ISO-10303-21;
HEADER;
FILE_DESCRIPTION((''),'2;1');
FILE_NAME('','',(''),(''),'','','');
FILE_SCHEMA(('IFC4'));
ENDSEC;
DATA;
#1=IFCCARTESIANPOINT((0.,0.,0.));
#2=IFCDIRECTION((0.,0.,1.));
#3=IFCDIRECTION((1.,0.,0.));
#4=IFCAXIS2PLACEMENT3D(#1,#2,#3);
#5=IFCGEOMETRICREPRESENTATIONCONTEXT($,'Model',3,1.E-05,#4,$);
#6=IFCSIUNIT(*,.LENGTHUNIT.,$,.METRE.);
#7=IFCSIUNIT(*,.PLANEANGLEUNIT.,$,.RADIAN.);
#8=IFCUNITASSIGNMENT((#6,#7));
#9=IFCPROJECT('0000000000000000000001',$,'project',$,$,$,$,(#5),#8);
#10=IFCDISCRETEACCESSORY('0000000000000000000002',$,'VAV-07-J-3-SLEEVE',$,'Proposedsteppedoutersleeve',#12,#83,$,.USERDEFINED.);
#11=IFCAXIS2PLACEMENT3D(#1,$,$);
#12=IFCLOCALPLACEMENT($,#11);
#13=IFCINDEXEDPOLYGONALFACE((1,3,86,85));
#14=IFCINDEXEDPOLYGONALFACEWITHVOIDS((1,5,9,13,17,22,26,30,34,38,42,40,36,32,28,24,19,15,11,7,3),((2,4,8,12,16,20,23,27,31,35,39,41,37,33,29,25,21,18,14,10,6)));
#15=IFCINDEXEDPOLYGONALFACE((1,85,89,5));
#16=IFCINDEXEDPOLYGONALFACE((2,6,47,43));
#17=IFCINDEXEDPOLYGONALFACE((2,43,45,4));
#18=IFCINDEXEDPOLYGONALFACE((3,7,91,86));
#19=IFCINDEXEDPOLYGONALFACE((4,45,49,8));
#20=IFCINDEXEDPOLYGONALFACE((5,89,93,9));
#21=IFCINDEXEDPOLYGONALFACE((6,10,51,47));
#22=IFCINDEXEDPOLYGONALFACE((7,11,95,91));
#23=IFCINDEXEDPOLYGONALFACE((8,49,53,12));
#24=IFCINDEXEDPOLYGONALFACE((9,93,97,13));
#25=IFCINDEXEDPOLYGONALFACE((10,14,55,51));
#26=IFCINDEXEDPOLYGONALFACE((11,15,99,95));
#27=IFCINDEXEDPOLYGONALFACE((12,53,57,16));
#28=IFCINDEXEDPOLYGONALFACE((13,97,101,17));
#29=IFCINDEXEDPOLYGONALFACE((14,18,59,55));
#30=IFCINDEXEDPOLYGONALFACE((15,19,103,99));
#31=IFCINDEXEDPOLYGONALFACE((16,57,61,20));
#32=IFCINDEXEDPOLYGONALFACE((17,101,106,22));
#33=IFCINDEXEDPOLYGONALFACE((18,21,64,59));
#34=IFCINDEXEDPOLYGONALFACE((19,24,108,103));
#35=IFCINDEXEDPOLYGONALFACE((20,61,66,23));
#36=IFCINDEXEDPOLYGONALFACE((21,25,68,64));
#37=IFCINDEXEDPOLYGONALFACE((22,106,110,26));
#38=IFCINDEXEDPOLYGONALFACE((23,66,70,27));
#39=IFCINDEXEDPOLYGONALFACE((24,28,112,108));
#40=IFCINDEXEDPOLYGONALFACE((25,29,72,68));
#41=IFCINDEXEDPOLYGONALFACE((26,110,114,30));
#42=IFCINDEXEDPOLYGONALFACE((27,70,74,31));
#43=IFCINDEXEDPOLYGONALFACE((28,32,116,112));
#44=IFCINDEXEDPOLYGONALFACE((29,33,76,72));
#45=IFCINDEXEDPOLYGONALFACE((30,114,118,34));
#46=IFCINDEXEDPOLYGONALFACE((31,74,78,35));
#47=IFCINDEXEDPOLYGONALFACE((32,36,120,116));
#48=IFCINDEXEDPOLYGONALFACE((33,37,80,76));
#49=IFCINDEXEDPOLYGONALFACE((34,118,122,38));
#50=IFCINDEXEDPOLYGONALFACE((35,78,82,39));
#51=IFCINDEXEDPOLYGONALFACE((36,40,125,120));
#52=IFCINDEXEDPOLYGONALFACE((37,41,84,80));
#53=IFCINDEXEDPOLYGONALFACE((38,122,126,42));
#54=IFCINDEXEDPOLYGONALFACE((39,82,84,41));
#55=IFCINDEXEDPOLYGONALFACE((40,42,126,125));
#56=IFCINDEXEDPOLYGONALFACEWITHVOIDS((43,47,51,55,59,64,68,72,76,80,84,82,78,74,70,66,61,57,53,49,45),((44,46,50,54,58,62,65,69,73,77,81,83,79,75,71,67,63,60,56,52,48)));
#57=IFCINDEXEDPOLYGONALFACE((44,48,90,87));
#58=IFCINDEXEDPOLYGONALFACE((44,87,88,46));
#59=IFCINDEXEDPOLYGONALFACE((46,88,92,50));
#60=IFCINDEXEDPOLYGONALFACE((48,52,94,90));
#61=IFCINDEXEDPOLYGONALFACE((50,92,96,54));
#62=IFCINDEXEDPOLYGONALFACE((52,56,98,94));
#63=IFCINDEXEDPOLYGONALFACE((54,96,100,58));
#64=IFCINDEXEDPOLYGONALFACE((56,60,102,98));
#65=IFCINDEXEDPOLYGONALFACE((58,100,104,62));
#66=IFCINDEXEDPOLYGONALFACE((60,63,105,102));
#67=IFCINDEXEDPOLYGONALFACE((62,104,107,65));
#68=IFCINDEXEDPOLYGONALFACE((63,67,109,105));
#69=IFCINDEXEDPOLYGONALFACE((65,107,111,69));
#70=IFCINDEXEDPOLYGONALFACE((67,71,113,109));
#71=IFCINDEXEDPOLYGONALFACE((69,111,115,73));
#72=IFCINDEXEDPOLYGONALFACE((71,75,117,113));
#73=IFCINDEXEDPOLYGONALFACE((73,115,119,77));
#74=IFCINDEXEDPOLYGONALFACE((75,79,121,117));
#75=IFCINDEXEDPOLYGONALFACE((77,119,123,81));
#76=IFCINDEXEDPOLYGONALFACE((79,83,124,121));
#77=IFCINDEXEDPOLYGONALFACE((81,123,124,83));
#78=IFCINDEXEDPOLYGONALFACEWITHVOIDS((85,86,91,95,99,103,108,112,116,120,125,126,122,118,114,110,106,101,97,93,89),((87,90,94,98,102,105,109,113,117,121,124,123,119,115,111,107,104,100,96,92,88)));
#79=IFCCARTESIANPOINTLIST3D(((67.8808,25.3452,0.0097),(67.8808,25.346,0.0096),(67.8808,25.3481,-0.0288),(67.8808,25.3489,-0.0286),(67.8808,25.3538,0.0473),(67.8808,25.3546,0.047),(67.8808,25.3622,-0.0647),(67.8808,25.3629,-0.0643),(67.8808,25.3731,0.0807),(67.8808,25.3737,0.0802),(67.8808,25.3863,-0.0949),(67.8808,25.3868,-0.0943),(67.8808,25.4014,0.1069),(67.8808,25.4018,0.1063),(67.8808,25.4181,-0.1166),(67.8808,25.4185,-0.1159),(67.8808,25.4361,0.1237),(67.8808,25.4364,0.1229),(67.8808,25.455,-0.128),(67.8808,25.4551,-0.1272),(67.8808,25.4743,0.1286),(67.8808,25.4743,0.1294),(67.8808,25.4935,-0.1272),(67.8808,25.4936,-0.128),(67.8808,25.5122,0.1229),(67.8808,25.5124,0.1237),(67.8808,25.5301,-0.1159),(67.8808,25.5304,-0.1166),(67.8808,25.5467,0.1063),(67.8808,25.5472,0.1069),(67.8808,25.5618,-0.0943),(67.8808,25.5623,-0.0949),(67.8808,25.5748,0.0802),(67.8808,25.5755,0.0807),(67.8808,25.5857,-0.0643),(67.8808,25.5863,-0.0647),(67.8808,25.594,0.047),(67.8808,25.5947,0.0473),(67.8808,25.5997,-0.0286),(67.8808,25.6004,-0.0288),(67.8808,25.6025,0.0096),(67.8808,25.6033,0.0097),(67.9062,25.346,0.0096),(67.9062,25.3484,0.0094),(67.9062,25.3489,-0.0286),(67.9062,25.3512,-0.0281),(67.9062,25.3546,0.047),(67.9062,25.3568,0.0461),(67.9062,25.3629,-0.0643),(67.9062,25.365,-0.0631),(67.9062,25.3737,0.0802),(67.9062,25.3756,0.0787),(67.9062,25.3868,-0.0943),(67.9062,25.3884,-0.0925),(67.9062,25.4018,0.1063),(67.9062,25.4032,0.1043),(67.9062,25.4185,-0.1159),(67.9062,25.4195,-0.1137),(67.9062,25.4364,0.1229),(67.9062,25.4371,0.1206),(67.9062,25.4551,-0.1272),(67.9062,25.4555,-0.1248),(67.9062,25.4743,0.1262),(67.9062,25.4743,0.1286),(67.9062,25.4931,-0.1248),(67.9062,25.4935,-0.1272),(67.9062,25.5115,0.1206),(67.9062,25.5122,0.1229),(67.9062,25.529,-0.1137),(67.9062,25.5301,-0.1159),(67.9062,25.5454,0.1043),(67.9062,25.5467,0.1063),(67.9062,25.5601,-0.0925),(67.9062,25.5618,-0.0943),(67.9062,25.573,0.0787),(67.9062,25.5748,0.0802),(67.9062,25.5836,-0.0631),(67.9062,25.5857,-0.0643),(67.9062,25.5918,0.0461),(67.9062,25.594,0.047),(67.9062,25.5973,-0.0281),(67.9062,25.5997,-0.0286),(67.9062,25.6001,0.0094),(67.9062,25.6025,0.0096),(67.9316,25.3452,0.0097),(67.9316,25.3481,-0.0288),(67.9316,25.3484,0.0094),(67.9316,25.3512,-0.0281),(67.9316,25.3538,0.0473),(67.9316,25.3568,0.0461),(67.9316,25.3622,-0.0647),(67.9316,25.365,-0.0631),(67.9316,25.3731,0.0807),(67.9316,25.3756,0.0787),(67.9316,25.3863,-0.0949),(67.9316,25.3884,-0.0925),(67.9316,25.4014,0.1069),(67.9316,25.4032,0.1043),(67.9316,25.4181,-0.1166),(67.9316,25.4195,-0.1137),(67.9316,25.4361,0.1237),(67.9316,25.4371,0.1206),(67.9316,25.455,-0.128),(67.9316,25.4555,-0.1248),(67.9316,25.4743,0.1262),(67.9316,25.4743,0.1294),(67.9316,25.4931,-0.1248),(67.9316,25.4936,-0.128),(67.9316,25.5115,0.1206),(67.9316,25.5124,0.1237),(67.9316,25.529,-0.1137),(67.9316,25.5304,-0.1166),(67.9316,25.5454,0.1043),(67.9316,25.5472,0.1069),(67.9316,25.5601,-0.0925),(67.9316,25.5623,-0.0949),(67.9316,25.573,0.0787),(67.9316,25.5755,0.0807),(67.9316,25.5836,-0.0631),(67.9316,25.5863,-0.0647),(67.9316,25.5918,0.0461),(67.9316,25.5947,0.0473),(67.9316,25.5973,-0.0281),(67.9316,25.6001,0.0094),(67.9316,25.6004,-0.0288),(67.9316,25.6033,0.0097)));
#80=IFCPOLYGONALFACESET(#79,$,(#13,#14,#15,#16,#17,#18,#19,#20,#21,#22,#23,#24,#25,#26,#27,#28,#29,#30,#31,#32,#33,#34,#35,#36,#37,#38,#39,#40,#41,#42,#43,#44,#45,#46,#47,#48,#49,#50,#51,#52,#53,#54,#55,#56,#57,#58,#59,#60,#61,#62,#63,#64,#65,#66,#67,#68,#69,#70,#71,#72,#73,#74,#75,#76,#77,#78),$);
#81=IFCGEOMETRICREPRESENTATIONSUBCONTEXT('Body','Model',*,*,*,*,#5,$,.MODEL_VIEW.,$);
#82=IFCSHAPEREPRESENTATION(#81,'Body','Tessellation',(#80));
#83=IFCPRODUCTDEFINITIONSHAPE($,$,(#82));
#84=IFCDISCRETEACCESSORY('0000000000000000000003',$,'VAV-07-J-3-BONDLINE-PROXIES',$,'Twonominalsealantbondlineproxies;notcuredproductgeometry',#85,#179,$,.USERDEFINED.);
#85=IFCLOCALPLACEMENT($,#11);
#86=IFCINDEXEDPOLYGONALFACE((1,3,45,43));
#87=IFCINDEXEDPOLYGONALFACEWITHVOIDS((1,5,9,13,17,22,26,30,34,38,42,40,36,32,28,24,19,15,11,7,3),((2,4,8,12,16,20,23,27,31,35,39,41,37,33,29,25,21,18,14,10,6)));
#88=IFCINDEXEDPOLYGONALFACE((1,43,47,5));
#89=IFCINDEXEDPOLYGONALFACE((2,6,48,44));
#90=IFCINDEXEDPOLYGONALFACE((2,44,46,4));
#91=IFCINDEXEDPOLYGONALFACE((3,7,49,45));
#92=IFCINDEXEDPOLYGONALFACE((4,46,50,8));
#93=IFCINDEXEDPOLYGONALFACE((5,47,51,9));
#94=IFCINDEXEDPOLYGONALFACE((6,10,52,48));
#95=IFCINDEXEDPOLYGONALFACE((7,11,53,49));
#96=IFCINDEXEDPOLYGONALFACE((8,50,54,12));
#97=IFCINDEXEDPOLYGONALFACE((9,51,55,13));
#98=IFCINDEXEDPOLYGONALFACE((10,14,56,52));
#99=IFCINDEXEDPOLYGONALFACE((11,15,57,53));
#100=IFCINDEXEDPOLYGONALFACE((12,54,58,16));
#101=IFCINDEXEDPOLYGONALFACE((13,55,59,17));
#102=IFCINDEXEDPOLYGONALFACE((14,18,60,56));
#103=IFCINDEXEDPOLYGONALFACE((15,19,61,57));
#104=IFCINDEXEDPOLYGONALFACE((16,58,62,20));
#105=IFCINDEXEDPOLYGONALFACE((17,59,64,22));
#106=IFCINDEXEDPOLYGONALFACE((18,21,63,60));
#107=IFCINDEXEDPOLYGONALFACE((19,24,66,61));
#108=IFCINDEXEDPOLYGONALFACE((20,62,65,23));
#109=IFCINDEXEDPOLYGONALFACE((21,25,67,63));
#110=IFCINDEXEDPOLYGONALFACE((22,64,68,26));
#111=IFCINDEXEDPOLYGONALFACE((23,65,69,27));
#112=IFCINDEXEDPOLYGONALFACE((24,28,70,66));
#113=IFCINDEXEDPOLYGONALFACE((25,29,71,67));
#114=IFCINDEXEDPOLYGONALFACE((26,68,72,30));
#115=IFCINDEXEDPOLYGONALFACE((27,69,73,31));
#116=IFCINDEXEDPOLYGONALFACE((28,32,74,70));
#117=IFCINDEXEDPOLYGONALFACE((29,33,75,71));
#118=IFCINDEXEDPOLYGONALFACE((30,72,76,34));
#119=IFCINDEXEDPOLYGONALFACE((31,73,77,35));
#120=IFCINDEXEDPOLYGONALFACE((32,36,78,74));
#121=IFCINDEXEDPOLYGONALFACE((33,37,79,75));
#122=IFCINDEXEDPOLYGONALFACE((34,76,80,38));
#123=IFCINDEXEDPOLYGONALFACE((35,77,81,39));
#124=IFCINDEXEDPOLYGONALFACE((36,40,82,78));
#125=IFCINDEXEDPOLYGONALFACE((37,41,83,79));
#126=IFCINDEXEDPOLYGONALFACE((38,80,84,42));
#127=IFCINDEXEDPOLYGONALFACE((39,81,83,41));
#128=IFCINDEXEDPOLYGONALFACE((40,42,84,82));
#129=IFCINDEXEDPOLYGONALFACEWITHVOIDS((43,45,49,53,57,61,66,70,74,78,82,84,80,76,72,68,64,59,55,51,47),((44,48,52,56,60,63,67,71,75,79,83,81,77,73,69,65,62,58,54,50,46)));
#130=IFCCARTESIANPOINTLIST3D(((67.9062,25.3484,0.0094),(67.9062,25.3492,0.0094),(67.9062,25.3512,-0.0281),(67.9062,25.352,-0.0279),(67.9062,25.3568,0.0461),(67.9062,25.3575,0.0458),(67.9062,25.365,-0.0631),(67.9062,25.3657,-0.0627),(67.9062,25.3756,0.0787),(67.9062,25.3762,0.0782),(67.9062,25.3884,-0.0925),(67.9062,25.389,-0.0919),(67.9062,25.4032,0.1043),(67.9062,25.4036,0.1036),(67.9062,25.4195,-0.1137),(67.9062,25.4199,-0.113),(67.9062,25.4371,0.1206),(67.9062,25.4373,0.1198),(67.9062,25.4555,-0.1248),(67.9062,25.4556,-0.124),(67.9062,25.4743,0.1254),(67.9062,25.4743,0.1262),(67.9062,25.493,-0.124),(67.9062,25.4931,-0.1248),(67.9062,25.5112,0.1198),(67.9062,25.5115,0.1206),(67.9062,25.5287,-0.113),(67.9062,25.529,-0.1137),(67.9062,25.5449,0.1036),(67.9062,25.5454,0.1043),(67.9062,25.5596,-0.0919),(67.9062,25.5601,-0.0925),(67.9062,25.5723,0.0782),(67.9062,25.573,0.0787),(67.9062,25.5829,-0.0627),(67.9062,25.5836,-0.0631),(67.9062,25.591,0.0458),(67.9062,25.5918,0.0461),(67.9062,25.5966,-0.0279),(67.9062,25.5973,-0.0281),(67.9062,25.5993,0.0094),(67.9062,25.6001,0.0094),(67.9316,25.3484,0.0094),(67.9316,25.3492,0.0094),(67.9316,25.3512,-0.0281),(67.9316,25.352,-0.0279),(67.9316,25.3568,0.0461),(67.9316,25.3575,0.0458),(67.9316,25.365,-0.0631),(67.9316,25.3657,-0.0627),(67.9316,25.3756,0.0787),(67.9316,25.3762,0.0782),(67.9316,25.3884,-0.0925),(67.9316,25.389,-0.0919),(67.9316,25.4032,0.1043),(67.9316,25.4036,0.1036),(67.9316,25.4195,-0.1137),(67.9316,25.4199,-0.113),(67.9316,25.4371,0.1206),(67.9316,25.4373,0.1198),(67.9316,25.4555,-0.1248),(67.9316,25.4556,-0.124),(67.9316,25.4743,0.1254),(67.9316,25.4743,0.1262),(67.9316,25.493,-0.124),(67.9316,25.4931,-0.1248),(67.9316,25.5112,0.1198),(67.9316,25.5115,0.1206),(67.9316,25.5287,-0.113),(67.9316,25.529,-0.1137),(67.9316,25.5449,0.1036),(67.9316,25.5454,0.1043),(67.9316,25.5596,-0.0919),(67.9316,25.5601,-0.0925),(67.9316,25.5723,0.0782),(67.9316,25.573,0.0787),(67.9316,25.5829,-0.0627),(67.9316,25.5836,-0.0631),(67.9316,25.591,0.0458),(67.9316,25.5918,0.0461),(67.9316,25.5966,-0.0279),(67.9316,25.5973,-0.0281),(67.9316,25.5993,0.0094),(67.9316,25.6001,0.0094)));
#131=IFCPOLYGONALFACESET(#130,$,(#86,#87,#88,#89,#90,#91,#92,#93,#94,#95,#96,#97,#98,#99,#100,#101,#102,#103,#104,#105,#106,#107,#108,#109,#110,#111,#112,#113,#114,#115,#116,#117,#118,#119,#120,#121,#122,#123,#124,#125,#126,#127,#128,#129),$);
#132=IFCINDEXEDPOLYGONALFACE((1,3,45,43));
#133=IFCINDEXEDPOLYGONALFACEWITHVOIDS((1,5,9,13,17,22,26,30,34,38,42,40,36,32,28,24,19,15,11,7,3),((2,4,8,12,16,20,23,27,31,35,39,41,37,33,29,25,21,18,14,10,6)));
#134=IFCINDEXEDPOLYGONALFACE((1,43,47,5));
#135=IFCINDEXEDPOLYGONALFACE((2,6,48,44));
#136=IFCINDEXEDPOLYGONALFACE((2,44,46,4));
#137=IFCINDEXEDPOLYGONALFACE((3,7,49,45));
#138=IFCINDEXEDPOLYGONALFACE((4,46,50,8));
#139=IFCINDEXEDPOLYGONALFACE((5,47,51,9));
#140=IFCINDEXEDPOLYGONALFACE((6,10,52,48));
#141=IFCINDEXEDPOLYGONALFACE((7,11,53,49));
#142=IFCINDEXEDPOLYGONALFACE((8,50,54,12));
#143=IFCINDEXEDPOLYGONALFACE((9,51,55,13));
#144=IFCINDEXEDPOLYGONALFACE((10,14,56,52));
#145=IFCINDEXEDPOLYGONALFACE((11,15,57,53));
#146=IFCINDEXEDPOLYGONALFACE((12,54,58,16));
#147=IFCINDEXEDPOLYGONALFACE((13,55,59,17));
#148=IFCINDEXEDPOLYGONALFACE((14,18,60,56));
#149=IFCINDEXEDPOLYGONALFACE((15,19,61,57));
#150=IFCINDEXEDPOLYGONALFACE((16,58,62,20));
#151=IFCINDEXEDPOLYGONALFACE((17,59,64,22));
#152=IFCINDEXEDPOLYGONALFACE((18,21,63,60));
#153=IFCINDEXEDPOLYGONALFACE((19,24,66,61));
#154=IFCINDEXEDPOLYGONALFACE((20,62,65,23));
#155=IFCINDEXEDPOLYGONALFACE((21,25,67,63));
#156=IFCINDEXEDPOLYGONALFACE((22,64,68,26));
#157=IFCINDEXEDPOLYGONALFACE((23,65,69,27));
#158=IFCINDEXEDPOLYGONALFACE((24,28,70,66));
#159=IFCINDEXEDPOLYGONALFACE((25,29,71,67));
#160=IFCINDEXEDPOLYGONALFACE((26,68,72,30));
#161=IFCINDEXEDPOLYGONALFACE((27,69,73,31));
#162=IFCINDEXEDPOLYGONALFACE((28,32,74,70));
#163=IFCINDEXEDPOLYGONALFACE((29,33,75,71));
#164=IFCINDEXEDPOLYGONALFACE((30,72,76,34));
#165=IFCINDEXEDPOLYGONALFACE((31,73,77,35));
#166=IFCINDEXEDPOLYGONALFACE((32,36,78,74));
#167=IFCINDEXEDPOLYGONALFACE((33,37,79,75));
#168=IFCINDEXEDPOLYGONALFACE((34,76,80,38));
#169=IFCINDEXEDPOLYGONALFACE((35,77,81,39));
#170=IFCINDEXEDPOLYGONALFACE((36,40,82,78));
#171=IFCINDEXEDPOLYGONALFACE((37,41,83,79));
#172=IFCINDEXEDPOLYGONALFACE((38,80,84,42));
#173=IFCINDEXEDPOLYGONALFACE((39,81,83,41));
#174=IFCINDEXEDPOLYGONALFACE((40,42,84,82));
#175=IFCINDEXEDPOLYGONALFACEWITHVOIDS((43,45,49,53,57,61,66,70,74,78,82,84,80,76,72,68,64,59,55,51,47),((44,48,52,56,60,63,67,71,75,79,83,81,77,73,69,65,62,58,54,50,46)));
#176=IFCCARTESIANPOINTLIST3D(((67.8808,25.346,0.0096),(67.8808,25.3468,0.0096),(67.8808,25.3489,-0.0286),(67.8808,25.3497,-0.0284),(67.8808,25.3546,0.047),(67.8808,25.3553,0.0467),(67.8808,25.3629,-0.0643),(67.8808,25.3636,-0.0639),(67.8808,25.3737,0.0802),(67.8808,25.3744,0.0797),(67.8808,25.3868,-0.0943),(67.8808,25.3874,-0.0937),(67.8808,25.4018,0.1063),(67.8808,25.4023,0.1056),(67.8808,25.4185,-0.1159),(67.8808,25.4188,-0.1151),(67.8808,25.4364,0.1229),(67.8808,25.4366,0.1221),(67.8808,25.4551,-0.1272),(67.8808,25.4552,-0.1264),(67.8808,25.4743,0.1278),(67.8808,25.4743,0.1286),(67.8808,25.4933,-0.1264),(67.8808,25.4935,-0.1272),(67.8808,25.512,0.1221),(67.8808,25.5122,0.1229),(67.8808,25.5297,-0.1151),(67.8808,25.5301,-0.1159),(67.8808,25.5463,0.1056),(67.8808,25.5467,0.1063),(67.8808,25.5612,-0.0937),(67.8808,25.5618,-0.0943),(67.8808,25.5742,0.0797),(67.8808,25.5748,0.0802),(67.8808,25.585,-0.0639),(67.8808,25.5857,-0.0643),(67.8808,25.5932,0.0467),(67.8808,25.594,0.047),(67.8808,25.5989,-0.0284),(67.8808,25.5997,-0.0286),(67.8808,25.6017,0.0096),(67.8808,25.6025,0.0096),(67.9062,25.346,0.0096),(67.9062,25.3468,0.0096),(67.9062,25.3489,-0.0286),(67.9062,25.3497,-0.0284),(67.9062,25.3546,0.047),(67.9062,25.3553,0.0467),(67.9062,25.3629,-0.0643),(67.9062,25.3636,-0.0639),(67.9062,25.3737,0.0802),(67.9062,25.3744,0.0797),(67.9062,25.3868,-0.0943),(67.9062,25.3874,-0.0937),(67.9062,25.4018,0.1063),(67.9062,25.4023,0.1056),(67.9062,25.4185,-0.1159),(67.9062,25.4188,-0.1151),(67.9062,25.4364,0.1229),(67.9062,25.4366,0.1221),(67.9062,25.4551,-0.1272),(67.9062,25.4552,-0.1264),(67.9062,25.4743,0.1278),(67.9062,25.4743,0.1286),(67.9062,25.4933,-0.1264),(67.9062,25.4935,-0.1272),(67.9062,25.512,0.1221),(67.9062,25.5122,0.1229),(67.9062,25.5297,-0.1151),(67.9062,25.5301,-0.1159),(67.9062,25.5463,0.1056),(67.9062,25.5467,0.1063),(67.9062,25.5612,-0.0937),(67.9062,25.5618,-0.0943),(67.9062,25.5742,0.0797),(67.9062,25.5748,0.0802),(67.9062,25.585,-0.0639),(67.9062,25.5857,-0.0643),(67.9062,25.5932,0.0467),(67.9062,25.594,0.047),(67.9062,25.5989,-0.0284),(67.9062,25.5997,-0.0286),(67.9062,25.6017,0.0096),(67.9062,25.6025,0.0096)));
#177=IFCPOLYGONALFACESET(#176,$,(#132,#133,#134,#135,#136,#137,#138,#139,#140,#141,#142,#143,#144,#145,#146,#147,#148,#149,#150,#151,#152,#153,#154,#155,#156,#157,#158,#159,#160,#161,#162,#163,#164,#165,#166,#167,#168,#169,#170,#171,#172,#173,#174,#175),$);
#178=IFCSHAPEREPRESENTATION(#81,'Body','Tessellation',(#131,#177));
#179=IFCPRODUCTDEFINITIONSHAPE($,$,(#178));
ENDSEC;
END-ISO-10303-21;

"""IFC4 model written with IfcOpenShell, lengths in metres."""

from ifc_helpers import new_model, entity, si_unit, frame, origin_with_axes, place, context, subcontext, project, element, save


model = new_model("IFC4")

# Units and contexts
model_context = context("Model", 3, precision=1e-05, world=origin_with_axes())
body_context = subcontext(model_context, "Body", "Model", "MODEL_VIEW")
ifc_project = project(units=[si_unit("LENGTHUNIT", "METRE"), si_unit("PLANEANGLEUNIT", "RADIAN")], contexts=[model_context])

# Discrete accessories
discrete_accessory_1_placement = place(None, frame((67.9062, 25.4743, 0.0), z_axis=(0.0, -1.0, 0.0), x_axis=(0.0, 0.0, 1.0)))
element("IfcDiscreteAccessory", 1, at=discrete_accessory_1_placement, Name="VAV-07-J-3-SLEEVE", ObjectType="Proposedsteppedoutersleeve", PredefinedType="USERDEFINED", context=body_context, shape_type="SweptSolid", body=[
    entity("IfcRevolvedAreaSolid", entity("IfcArbitraryClosedProfileDef", "AREA", None, entity("IfcPolyline", [entity("IfcCartesianPoint", [0.1262, -0.0254]), entity("IfcCartesianPoint", [0.1294, -0.0254]), entity("IfcCartesianPoint", [0.1294, 0.0254]), entity("IfcCartesianPoint", [0.1286, 0.0254]), entity("IfcCartesianPoint", [0.1286, 0.0]), entity("IfcCartesianPoint", [0.1262, 0.0]), entity("IfcCartesianPoint", [0.1262, -0.0254])])), entity("IfcAxis2Placement3D", entity("IfcCartesianPoint", [0.0, 0.0, 0.0])), entity("IfcAxis1Placement", entity("IfcCartesianPoint", [0.0, 0.0, 0.0]), entity("IfcDirection", [0.0, 1.0, 0.0])), 6.283185),
])
discrete_accessory_2_placement = place(None, frame((67.9062, 25.4743, 0.0), z_axis=(0.0, -1.0, 0.0), x_axis=(0.0, 0.0, 1.0)))
element("IfcDiscreteAccessory", 2, at=discrete_accessory_2_placement, Name="VAV-07-J-3-BONDLINE-PROXIES", ObjectType="Twonominalsealantbondlineproxies;notcuredproductgeometry", PredefinedType="USERDEFINED", context=body_context, shape_type="SweptSolid", body=[
    entity("IfcRevolvedAreaSolid", entity("IfcArbitraryClosedProfileDef", "AREA", None, entity("IfcPolyline", [entity("IfcCartesianPoint", [0.1254, -0.0254]), entity("IfcCartesianPoint", [0.1262, -0.0254]), entity("IfcCartesianPoint", [0.1262, 0.0]), entity("IfcCartesianPoint", [0.1254, 0.0]), entity("IfcCartesianPoint", [0.1254, -0.0254])])), entity("IfcAxis2Placement3D", entity("IfcCartesianPoint", [0.0, 0.0, 0.0])), entity("IfcAxis1Placement", entity("IfcCartesianPoint", [0.0, 0.0, 0.0]), entity("IfcDirection", [0.0, 1.0, 0.0])), 6.283185),
    entity("IfcRevolvedAreaSolid", entity("IfcArbitraryClosedProfileDef", "AREA", None, entity("IfcPolyline", [entity("IfcCartesianPoint", [0.1278, 0.0]), entity("IfcCartesianPoint", [0.1286, 0.0]), entity("IfcCartesianPoint", [0.1286, 0.0254]), entity("IfcCartesianPoint", [0.1278, 0.0254]), entity("IfcCartesianPoint", [0.1278, 0.0])])), entity("IfcAxis2Placement3D", entity("IfcCartesianPoint", [0.0, 0.0, 0.0])), entity("IfcAxis1Placement", entity("IfcCartesianPoint", [0.0, 0.0, 0.0]), entity("IfcDirection", [0.0, 1.0, 0.0])), 6.283185),
])

save(model, "model.ifc")
